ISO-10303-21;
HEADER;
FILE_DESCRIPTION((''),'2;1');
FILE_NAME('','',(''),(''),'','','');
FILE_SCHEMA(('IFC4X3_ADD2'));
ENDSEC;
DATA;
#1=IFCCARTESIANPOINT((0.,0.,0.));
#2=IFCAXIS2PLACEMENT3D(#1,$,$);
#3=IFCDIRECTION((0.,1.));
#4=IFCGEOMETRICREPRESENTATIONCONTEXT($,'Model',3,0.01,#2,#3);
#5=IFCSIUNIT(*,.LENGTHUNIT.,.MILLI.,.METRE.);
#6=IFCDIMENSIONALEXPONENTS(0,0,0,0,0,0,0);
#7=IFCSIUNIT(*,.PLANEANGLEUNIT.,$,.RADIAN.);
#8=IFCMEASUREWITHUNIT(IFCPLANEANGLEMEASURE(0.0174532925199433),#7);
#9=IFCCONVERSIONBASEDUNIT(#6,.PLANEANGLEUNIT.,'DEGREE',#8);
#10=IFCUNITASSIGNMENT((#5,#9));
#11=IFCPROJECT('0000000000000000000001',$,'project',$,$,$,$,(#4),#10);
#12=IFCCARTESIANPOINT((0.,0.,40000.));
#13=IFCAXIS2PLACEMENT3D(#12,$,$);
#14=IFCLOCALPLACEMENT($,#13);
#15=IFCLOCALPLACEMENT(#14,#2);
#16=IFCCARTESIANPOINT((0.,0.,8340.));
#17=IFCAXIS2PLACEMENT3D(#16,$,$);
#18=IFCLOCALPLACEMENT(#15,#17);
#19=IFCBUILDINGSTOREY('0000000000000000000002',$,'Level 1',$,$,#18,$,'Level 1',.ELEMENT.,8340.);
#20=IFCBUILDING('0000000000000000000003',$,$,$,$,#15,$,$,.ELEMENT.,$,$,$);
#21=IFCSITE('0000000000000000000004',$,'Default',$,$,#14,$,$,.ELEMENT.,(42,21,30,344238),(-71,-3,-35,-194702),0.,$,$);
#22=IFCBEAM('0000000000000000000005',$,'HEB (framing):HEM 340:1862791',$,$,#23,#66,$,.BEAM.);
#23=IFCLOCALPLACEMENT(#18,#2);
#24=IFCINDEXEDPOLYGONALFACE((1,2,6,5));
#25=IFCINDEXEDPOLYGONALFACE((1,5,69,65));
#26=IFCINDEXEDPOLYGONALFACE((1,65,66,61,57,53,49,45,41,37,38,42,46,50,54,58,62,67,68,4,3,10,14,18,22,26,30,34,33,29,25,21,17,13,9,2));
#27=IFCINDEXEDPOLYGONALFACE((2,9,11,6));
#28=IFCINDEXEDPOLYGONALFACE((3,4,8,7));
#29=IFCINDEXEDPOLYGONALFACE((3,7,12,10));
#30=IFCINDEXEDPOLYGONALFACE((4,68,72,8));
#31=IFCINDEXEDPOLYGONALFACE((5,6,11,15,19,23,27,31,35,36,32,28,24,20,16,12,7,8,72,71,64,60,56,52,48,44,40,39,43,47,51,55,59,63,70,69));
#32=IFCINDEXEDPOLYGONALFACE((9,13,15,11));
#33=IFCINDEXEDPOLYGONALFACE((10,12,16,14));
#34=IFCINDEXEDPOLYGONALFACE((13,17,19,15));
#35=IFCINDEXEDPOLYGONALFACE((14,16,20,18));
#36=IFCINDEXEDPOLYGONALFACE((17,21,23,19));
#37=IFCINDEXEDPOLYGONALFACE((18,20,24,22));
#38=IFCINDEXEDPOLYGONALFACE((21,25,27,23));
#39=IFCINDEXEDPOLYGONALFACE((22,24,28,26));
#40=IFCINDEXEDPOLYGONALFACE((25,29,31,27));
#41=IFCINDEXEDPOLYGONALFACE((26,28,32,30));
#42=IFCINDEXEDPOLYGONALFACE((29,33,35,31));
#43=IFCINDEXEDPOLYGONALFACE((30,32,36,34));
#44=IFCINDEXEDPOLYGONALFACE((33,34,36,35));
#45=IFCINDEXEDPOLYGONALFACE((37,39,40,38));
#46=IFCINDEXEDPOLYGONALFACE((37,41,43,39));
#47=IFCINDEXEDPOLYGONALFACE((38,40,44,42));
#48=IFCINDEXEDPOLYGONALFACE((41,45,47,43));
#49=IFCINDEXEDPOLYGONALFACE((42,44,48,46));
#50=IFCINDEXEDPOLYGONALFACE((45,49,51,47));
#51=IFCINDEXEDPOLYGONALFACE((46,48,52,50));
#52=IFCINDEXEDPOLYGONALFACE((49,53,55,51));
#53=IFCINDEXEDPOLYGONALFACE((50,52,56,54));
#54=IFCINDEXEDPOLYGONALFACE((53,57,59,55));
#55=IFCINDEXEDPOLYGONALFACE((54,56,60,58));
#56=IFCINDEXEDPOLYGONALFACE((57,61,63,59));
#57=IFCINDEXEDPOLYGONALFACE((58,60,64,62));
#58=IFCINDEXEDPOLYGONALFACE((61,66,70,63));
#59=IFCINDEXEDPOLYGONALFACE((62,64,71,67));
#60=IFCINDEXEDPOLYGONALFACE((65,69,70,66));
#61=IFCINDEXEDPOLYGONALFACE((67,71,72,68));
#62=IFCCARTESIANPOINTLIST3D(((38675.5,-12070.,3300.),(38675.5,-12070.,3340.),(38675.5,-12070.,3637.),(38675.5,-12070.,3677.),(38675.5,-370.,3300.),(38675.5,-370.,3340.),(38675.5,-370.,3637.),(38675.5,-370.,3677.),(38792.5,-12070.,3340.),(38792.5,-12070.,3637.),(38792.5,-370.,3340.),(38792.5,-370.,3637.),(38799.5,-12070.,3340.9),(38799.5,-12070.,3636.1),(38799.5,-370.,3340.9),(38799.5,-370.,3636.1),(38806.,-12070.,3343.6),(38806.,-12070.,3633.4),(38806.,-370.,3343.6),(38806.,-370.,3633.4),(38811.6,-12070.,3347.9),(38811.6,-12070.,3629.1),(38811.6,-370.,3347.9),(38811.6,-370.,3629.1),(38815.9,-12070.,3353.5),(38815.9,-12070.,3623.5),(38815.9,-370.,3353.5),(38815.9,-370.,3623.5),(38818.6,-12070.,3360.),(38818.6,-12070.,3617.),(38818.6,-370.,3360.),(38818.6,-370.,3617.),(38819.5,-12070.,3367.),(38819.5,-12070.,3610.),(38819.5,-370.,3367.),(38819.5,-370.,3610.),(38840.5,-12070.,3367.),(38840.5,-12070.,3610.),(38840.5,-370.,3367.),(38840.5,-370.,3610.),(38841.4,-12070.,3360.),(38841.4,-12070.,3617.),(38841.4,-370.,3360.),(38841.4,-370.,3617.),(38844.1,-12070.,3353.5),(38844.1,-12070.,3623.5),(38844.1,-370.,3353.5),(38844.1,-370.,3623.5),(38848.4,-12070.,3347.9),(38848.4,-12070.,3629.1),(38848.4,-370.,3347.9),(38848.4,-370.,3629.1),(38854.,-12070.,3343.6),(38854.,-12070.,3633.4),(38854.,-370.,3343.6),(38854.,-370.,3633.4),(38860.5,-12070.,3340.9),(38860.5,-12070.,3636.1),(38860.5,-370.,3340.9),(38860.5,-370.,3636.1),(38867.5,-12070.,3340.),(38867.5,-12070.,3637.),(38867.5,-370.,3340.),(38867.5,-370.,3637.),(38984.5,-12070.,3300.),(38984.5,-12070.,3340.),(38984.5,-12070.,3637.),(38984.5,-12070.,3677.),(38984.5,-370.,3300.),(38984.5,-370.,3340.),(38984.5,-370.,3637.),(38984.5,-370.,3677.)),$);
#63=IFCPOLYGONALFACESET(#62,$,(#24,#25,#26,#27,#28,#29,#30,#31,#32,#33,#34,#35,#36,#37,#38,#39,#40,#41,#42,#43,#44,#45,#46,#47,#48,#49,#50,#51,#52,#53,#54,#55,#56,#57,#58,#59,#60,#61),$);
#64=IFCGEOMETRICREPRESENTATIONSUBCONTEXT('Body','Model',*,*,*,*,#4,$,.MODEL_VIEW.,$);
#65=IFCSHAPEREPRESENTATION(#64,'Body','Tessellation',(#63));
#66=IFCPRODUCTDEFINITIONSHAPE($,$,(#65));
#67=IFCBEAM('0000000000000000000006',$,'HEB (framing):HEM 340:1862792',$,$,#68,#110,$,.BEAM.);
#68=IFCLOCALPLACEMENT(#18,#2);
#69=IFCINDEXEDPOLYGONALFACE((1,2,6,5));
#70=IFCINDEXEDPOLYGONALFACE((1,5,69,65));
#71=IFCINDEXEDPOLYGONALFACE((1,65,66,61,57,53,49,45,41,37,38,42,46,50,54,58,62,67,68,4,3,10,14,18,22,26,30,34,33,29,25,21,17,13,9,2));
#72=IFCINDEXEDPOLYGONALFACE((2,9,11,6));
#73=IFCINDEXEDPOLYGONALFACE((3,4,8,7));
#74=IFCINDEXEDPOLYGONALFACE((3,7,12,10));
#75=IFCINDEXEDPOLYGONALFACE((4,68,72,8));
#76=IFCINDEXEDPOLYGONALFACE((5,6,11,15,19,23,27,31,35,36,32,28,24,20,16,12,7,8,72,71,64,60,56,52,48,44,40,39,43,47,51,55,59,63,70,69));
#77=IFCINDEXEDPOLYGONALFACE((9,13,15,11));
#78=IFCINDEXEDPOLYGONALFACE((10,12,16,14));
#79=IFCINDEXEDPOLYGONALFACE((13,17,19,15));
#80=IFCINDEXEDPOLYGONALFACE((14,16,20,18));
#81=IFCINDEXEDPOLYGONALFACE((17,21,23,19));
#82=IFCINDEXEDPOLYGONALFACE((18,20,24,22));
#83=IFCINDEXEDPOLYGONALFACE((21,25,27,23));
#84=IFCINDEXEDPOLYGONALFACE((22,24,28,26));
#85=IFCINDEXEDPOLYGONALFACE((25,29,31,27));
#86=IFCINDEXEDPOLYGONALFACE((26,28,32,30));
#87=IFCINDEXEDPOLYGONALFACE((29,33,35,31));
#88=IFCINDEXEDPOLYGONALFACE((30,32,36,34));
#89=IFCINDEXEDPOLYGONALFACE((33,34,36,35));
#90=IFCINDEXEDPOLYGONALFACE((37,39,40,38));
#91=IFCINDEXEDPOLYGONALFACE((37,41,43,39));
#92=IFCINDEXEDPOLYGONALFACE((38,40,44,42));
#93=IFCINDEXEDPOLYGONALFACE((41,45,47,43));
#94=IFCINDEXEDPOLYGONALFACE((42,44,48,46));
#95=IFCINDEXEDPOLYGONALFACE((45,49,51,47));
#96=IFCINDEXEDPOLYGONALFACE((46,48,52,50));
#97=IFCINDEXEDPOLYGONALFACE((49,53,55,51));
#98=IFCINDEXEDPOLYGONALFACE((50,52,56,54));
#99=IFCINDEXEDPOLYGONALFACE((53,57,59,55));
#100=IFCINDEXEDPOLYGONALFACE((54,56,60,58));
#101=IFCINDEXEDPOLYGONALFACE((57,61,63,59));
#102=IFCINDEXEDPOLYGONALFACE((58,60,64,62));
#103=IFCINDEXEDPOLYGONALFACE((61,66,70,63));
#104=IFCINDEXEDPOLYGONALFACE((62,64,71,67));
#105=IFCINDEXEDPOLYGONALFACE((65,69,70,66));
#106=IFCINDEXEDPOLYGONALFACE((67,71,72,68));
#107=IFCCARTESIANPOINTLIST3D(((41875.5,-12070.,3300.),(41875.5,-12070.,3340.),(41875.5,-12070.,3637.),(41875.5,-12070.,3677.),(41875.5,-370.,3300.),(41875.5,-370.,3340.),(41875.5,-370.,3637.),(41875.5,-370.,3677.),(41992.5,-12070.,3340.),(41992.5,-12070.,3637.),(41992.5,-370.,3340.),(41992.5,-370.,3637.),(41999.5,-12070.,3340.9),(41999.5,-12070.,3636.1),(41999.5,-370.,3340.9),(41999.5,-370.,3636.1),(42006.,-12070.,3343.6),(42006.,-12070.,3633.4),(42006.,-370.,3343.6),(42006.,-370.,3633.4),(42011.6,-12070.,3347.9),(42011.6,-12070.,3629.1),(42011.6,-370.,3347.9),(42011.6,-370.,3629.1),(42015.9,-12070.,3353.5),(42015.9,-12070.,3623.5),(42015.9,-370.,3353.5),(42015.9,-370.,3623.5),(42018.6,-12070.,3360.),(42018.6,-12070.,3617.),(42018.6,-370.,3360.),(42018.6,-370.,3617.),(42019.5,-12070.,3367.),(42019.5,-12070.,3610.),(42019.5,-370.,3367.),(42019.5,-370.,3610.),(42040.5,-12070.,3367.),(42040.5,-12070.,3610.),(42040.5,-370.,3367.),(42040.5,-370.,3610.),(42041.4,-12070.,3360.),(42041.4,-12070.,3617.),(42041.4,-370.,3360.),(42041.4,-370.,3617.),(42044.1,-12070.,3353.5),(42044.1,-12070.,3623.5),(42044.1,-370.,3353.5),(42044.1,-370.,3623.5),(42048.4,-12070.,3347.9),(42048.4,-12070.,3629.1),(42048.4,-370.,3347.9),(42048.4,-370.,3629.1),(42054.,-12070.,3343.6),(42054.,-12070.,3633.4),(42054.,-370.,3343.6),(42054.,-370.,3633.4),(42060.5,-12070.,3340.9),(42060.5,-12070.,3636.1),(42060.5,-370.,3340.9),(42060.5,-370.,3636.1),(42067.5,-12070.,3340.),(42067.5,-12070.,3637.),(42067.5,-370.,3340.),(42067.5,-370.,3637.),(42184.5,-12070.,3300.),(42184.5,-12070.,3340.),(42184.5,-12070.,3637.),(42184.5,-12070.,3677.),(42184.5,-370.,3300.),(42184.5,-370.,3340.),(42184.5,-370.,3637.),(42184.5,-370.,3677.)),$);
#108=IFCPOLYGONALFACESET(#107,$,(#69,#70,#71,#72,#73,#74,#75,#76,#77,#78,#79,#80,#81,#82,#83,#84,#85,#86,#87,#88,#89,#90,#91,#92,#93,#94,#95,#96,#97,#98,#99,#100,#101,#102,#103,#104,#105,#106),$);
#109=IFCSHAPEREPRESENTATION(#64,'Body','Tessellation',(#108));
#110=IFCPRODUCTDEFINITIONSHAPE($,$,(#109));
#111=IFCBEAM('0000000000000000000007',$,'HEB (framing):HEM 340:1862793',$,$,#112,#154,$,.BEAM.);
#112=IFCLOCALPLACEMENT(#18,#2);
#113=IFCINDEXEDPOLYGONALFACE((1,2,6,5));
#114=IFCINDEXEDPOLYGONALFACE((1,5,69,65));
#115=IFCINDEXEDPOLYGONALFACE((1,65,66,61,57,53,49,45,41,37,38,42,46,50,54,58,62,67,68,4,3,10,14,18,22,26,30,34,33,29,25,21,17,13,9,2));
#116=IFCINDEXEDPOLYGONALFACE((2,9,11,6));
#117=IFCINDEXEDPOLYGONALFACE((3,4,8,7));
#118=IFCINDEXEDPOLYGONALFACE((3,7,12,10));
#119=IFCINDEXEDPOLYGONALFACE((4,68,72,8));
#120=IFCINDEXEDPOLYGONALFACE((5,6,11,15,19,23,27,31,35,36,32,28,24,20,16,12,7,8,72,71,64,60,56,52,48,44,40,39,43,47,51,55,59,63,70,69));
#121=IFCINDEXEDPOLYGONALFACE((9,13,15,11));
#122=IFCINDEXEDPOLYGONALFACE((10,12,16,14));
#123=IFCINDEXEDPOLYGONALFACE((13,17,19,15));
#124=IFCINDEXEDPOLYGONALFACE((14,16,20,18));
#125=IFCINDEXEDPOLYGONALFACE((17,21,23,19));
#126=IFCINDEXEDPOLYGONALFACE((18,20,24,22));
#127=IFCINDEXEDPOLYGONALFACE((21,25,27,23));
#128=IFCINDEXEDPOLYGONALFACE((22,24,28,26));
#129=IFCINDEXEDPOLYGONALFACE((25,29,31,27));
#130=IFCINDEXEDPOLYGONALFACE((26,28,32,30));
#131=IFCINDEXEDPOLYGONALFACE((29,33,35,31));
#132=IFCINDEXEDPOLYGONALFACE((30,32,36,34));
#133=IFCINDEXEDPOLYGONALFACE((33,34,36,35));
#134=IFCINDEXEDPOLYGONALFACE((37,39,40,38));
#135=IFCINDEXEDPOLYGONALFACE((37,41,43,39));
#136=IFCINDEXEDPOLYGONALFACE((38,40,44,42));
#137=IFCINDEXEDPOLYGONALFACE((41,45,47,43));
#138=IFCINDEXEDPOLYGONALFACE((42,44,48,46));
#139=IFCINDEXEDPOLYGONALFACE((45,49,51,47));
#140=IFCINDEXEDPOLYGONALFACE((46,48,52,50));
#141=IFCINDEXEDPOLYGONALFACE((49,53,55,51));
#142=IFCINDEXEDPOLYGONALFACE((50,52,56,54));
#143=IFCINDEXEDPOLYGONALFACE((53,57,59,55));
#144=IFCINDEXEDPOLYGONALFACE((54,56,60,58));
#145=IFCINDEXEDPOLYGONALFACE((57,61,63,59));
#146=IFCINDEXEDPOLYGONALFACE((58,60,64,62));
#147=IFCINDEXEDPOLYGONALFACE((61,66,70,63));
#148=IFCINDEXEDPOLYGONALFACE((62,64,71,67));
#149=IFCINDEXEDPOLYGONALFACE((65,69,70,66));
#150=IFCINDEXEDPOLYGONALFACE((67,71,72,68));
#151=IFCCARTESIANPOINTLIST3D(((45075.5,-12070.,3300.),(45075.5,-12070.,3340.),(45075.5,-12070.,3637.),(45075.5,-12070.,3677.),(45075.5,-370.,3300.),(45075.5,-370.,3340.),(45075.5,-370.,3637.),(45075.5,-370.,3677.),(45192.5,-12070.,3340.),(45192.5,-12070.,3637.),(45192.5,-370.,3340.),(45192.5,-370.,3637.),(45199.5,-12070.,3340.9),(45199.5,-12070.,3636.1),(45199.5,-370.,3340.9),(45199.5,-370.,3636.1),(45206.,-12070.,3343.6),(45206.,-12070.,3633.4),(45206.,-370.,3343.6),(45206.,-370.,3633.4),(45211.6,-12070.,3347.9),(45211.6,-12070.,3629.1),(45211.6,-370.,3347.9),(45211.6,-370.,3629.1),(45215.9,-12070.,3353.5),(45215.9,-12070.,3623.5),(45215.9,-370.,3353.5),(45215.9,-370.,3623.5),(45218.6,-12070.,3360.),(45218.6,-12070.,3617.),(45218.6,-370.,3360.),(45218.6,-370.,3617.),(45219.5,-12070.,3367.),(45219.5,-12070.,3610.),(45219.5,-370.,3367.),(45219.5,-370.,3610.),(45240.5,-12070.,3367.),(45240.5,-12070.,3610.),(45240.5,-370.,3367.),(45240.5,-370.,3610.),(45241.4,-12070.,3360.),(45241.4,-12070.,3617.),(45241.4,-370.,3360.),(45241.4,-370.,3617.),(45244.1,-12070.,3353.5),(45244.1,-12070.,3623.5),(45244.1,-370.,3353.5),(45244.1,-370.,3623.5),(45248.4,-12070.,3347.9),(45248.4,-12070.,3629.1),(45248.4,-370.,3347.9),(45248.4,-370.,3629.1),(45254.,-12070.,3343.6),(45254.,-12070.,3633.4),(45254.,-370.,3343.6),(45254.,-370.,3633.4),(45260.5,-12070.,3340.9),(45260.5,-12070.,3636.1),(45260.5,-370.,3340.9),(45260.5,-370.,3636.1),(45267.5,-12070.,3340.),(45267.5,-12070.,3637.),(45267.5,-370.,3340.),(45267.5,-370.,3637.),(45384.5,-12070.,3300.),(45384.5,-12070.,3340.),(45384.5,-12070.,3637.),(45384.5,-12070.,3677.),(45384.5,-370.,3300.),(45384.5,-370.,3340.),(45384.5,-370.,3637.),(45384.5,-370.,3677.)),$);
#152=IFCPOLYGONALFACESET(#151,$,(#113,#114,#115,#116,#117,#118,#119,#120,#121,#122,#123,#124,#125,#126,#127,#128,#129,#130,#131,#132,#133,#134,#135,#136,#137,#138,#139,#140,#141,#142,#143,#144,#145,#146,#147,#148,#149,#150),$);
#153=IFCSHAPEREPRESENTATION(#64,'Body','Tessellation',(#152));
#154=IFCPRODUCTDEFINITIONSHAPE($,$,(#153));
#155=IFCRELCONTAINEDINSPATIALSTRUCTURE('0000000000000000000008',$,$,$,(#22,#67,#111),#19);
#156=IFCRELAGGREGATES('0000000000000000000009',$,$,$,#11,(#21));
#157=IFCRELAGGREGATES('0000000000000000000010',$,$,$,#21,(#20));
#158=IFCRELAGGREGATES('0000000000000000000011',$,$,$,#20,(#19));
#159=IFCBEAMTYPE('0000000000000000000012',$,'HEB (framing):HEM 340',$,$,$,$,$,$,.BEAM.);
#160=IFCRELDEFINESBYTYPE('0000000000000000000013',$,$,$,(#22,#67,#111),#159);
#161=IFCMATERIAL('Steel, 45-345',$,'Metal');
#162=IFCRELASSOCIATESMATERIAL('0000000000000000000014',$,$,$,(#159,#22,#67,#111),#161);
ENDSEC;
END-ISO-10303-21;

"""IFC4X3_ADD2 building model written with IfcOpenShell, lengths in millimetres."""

from ifc_helpers import new_model, entity, si_unit, converted_unit, direction, frame, frame_2d, origin, place, context, subcontext, project, spatial, polyline, circle_curve, parameter, trimmed, segment, composite_curve, outline, extrude, source, transform, mapped, material, material_profile, profile_set, profile_usage, type_object, type_shapes, element, save


model = new_model("IFC4X3_ADD2")

# Units and contexts
model_context = context("Model", 3, precision=0.01, world=origin(), true_north=direction((0.0, 1.0)))
body_context = subcontext(model_context, "Body", "Model", "MODEL_VIEW")
ifc_project = project(units=[si_unit("LENGTHUNIT", "METRE", prefix="MILLI"), converted_unit("PLANEANGLEUNIT", "DEGREE", entity("IfcPlaneAngleMeasure", 0.0174532925199433), si_unit("PLANEANGLEUNIT", "RADIAN"), dimensions=[0, 0, 0, 0, 0, 0, 0])], contexts=[model_context])

# Site, building, storey
site_placement = place(None, frame((0.0, 0.0, 40000.0)))
site = spatial("IfcSite", under=ifc_project, at=site_placement, Name="Default", CompositionType="ELEMENT", RefLatitude=(42, 21, 30, 344238), RefLongitude=(-71, -3, -35, -194702), RefElevation=0.0)
building_placement = place(site_placement, origin())
building = spatial("IfcBuilding", under=site, at=building_placement, CompositionType="ELEMENT")
storey_placement = place(building_placement, frame((0.0, 0.0, 8340.0)))
storey = spatial("IfcBuildingStorey", under=building, at=storey_placement, Name="Level 1", LongName="Level 1", CompositionType="ELEMENT", Elevation=8340.0)

# Shared definitions
ifc_material = material(Name="Steel, 45-345", Category="Metal")

# Beams
ifc_material_profile_1 = material_profile(ifc_material, outline(composite_curve([segment(polyline([(-154.5, -148.5), (-154.5, -188.5)]), True, "CONTINUOUS"), segment(polyline([(-154.5, -188.5), (154.5, -188.5)]), True, "CONTINUOUS"), segment(polyline([(154.5, -188.5), (154.5, -148.5)]), True, "CONTINUOUS"), segment(polyline([(154.5, -148.5), (37.5, -148.5)]), True, "CONTINUOUS"), segment(trimmed(circle_curve(frame_2d((37.5, -121.5), x_axis=(1.0, 0.0)), 27.0), [parameter(180.0)], [parameter(270.0)], True, "PARAMETER"), False, "CONTINUOUS"), segment(polyline([(10.5, -121.5), (10.5, 121.5)]), True, "CONTINUOUS"), segment(trimmed(circle_curve(frame_2d((37.5, 121.5), x_axis=(1.0, 0.0)), 27.0), [parameter(90.0)], [parameter(180.0)], True, "PARAMETER"), False, "CONTINUOUS"), segment(polyline([(37.5, 148.5), (154.5, 148.5)]), True, "CONTINUOUS"), segment(polyline([(154.5, 148.5), (154.5, 188.5)]), True, "CONTINUOUS"), segment(polyline([(154.5, 188.5), (-154.5, 188.5)]), True, "CONTINUOUS"), segment(polyline([(-154.5, 188.5), (-154.5, 148.5)]), True, "CONTINUOUS"), segment(polyline([(-154.5, 148.5), (-37.5, 148.5)]), True, "CONTINUOUS"), segment(trimmed(circle_curve(frame_2d((-37.5, 121.5), x_axis=(1.0, 0.0)), 27.0), [parameter(360.0)], [parameter(90.0)], True, "PARAMETER"), False, "CONTINUOUS"), segment(polyline([(-10.5, 121.5), (-10.5, -121.5)]), True, "CONTINUOUS"), segment(trimmed(circle_curve(frame_2d((-37.5, -121.5), x_axis=(1.0, 0.0)), 27.0), [parameter(270.0)], [parameter(0.0)], True, "PARAMETER"), False, "CONTINUOUS"), segment(polyline([(-37.5, -148.5), (-154.5, -148.5)]), True, "CONTINUOUS")], self_intersect=False)), Name="HEM 340")
ifc_profile_set_1 = profile_set([ifc_material_profile_1], Name="HEM 340")
ifc_profile_usage_1 = profile_usage(ifc_profile_set_1, cardinal=8)
beam_type_1 = type_object("IfcBeamType", Name="HEB (framing):HEM 340", PredefinedType="BEAM", material=ifc_profile_set_1)
shared_shape_1 = source(origin(), body_context, "Body", "SweptSolid", [
    extrude(outline(composite_curve([segment(polyline([(-154.5, -148.5), (-154.5, -188.5)]), True, "CONTINUOUS"), segment(polyline([(-154.5, -188.5), (154.5, -188.5)]), True, "CONTINUOUS"), segment(polyline([(154.5, -188.5), (154.5, -148.5)]), True, "CONTINUOUS"), segment(polyline([(154.5, -148.5), (37.5, -148.5)]), True, "CONTINUOUS"), segment(trimmed(circle_curve(frame_2d((37.5, -121.5), x_axis=(1.0, 0.0)), 27.0), [parameter(180.0)], [parameter(270.0)], True, "PARAMETER"), False, "CONTINUOUS"), segment(polyline([(10.5, -121.5), (10.5, 121.5)]), True, "CONTINUOUS"), segment(trimmed(circle_curve(frame_2d((37.5, 121.5), x_axis=(1.0, 0.0)), 27.0), [parameter(90.0)], [parameter(180.0)], True, "PARAMETER"), False, "CONTINUOUS"), segment(polyline([(37.5, 148.5), (154.5, 148.5)]), True, "CONTINUOUS"), segment(polyline([(154.5, 148.5), (154.5, 188.5)]), True, "CONTINUOUS"), segment(polyline([(154.5, 188.5), (-154.5, 188.5)]), True, "CONTINUOUS"), segment(polyline([(-154.5, 188.5), (-154.5, 148.5)]), True, "CONTINUOUS"), segment(polyline([(-154.5, 148.5), (-37.5, 148.5)]), True, "CONTINUOUS"), segment(trimmed(circle_curve(frame_2d((-37.5, 121.5), x_axis=(1.0, 0.0)), 27.0), [parameter(360.0)], [parameter(90.0)], True, "PARAMETER"), False, "CONTINUOUS"), segment(polyline([(-10.5, 121.5), (-10.5, -121.5)]), True, "CONTINUOUS"), segment(trimmed(circle_curve(frame_2d((-37.5, -121.5), x_axis=(1.0, 0.0)), 27.0), [parameter(270.0)], [parameter(0.0)], True, "PARAMETER"), False, "CONTINUOUS"), segment(polyline([(-37.5, -148.5), (-154.5, -148.5)]), True, "CONTINUOUS")], self_intersect=False)), frame((-5850.0, 0.0, 0.0), z_axis=(-1.0, 0.0, 0.0), x_axis=(0.0, -1.0, 0.0)), (0.0, 0.0, -1.0), 11700.0),
])
type_shapes(beam_type_1, [shared_shape_1])
for number, where, z_axis, x_axis, name in (
    (1, (38830.0, -6220.0, 3488.5), (0.0, 0.0, 1.0), (0.0, -1.0, 0.0), "HEB (framing):HEM 340:1862791"),
    (2, (42030.0, -6220.0, 3488.5), (0.0, 0.0, 1.0), (0.0, -1.0, 0.0), "HEB (framing):HEM 340:1862792"),
    (3, (45230.0, -6220.0, 3488.5), (0.0, 0.0, 1.0), (0.0, -1.0, 0.0), "HEB (framing):HEM 340:1862793"),
):
    element("IfcBeam", number, at=place(storey_placement, frame(where, z_axis=z_axis, x_axis=x_axis)), inside=storey, type_object=beam_type_1, material=ifc_profile_usage_1, Name=name, PredefinedType="BEAM", context=body_context, shape_type="MappedRepresentation", body=[
        mapped(shared_shape_1, transform((0.0, 0.0, 0.0), scale=1.0)),
    ])

save(model, "model.ifc")
